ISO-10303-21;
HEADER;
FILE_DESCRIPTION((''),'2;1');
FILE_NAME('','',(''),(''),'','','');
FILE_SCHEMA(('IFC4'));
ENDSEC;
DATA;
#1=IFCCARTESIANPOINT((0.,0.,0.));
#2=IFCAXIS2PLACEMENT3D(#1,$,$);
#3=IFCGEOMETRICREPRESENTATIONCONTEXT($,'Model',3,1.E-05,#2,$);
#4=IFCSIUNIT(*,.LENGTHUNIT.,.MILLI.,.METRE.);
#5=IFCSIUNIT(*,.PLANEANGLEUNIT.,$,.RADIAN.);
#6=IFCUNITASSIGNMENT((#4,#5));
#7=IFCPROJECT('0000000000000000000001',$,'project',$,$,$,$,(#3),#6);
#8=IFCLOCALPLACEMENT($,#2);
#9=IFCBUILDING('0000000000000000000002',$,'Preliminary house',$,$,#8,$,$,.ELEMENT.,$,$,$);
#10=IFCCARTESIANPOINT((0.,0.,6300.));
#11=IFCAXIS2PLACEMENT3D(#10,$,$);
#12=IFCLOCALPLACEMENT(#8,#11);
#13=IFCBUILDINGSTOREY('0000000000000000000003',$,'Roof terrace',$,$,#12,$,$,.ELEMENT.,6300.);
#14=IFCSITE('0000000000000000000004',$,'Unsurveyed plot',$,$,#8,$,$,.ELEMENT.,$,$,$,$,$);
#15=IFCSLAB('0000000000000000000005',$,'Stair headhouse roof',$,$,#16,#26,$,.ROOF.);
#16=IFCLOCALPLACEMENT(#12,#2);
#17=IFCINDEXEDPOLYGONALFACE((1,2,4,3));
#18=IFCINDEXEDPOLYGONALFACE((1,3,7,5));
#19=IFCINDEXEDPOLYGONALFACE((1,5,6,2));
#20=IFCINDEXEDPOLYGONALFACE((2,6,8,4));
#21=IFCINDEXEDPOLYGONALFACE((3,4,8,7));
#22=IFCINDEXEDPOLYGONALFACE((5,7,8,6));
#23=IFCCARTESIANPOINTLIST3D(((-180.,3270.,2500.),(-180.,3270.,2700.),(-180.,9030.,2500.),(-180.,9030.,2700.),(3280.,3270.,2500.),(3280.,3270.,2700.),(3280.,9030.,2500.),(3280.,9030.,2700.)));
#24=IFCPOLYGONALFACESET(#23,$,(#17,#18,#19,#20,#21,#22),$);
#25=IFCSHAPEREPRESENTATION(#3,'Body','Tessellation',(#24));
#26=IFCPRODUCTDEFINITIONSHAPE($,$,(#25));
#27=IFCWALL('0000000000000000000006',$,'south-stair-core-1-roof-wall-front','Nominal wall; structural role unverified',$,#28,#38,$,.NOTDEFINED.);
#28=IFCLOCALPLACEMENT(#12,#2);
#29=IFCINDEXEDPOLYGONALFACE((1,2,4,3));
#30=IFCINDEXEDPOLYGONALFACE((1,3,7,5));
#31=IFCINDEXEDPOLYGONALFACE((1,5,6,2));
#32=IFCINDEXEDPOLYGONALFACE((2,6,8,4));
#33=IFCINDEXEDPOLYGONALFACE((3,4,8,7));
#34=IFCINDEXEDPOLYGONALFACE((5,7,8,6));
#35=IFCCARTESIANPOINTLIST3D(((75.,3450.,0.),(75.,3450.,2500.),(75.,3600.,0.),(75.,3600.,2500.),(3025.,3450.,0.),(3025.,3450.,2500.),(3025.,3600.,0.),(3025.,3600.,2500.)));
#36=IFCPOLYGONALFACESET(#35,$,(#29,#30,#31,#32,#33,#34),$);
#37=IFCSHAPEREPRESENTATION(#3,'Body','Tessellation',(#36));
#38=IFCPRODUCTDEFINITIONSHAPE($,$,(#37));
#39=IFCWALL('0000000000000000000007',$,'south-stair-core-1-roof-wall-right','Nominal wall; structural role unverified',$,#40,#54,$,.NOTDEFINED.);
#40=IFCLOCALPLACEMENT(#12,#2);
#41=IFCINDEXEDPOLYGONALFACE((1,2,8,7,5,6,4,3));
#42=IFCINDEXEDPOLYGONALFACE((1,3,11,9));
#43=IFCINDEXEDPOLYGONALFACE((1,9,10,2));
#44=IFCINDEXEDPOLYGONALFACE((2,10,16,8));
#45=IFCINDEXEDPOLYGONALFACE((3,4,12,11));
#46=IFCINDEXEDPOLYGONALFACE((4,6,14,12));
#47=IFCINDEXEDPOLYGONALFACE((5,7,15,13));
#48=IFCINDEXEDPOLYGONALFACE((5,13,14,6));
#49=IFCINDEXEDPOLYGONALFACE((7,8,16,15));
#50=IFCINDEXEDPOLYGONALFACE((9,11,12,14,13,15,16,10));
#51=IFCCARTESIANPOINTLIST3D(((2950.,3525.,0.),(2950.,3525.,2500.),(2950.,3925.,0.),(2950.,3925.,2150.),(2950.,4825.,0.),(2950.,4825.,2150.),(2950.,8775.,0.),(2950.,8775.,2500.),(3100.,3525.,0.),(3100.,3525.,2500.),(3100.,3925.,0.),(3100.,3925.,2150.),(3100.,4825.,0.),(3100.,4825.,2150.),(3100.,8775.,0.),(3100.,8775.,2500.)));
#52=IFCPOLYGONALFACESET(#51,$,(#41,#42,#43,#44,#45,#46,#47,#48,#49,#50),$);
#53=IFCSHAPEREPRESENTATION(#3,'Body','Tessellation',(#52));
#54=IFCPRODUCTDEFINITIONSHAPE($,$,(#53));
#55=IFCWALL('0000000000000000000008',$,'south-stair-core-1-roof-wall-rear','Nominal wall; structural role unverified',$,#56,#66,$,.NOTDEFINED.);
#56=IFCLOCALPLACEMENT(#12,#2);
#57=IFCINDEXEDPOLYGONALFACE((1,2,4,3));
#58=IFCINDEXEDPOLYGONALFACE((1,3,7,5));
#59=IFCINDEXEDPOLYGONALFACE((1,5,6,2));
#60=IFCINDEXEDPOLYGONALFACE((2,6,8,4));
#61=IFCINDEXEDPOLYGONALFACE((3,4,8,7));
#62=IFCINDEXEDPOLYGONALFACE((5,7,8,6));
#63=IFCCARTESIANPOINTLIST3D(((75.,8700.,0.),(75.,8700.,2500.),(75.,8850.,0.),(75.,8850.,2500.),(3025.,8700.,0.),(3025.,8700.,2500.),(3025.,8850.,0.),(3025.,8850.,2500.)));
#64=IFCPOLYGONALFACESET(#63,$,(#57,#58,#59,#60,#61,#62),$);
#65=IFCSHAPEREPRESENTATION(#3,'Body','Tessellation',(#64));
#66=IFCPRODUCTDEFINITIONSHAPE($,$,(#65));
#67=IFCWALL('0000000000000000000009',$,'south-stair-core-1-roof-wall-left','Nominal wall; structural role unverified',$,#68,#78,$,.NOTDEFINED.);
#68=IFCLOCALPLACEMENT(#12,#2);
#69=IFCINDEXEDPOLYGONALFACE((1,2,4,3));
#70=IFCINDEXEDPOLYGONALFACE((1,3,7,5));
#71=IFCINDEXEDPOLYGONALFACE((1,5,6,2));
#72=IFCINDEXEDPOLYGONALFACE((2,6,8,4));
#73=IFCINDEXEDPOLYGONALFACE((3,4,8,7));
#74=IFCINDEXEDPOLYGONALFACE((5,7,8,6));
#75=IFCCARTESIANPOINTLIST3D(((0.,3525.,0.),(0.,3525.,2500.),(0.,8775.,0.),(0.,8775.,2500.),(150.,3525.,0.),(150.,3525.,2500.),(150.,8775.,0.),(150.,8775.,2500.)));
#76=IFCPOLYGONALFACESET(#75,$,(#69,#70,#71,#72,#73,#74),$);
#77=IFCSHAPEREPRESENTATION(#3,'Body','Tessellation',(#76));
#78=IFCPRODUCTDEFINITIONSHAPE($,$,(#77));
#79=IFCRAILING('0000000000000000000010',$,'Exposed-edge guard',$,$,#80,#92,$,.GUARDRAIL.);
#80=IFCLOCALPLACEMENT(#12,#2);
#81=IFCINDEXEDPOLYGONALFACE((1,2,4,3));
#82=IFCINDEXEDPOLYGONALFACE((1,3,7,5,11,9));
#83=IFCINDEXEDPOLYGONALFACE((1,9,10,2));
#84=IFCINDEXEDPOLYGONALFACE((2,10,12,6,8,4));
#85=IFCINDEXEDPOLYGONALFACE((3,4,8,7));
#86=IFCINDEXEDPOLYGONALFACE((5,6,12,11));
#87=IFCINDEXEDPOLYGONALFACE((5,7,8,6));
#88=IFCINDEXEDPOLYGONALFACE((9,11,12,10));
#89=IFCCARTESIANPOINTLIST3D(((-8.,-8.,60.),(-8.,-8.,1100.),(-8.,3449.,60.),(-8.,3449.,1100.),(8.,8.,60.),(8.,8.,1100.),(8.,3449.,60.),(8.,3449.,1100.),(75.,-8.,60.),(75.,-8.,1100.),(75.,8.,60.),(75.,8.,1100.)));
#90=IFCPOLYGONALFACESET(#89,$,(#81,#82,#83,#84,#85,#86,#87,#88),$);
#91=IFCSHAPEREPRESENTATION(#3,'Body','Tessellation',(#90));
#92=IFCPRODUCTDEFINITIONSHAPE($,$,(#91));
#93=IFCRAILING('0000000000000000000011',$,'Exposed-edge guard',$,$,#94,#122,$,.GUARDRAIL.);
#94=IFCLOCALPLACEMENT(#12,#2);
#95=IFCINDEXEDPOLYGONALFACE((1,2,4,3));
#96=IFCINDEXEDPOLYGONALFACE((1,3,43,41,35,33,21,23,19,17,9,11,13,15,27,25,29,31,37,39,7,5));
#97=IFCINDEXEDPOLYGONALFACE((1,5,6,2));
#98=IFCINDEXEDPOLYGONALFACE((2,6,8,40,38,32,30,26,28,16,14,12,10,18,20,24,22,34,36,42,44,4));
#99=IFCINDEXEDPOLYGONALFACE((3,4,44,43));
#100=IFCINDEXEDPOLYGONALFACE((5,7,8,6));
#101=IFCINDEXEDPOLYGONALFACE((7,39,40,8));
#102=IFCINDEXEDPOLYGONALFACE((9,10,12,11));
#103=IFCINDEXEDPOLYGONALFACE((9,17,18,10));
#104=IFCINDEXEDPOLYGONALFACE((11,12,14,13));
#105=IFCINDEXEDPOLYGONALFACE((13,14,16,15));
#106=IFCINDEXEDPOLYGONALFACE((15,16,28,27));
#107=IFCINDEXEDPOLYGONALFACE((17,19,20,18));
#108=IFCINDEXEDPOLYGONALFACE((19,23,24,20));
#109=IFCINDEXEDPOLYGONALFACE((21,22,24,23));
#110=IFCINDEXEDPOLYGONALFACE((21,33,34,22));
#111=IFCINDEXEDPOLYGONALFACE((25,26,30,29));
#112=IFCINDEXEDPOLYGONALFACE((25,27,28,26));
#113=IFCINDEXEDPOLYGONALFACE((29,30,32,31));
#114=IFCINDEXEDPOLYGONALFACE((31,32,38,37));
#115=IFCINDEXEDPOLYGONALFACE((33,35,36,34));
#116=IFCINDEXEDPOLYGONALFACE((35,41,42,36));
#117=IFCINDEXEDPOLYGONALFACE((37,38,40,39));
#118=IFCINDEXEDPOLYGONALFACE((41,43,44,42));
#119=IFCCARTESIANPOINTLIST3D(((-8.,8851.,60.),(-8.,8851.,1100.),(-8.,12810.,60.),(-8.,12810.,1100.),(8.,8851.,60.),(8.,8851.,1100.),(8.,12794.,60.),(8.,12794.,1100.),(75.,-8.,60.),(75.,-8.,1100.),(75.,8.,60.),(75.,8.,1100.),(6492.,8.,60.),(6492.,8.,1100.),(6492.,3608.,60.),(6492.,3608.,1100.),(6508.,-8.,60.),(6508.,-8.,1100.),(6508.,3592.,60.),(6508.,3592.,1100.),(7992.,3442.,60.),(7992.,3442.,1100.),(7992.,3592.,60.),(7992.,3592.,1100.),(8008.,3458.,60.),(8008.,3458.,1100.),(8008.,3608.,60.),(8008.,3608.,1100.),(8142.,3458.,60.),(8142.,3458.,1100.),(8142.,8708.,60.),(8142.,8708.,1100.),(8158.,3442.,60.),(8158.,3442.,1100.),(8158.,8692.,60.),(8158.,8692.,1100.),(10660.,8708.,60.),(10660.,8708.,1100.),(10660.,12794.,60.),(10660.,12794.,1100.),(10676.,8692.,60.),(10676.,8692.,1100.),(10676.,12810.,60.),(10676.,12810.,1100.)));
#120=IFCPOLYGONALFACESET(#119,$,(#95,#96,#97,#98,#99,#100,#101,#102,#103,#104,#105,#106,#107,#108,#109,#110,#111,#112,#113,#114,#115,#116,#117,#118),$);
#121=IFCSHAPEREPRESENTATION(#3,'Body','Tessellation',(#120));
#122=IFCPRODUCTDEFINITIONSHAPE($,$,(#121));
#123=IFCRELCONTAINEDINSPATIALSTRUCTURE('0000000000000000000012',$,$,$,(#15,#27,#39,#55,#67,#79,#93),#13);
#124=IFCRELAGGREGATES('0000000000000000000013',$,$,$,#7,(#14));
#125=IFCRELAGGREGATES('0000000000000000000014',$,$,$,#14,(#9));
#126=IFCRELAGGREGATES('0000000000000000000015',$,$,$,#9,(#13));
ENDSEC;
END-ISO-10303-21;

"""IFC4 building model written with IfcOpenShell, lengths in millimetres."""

from ifc_helpers import new_model, si_unit, frame, origin, place, context, project, spatial, polyline, outline, extrude, element, save


model = new_model("IFC4")

# Units and contexts
model_context = context("Model", 3, precision=1e-05, world=origin())
ifc_project = project(units=[si_unit("LENGTHUNIT", "METRE", prefix="MILLI"), si_unit("PLANEANGLEUNIT", "RADIAN")], contexts=[model_context])

# Site, building, storey
placement_1 = place(None, origin())
site = spatial("IfcSite", under=ifc_project, at=placement_1, Name="Unsurveyed plot", CompositionType="ELEMENT")
building = spatial("IfcBuilding", under=site, at=placement_1, Name="Preliminary house", CompositionType="ELEMENT")
placement_2 = place(placement_1, frame((0.0, 0.0, 6300.0)))
storey = spatial("IfcBuildingStorey", under=building, at=placement_2, Name="Roof terrace", CompositionType="ELEMENT", Elevation=6300.0)

# Slab
element("IfcSlab", 1, at=placement_2, inside=storey, Name="Stair headhouse roof", PredefinedType="ROOF", context=model_context, shape_type="SweptSolid", body=[
    extrude(outline(polyline([(3280.0, 3270.0), (-180.0, 3270.0), (-180.0, 9030.0), (3280.0, 9030.0), (3280.0, 3270.0)])), frame((0.0, 0.0, 2500.0)), (0.0, 0.0, 1.0), 200.0),
])

# Wall
element("IfcWall", 2, at=placement_2, inside=storey, Name="south-stair-core-1-roof-wall-front", Description="Nominal wall; structural role unverified", PredefinedType="NOTDEFINED", context=model_context, shape_type="SweptSolid", body=[
    extrude(outline(polyline([(3025.0, 3600.0), (3025.0, 3450.0), (75.0, 3450.0), (75.0, 3600.0), (3025.0, 3600.0)])), origin(), (0.0, 0.0, 1.0), 2500.0),
])

# Wall, opening
wall_1 = element("IfcWall", 3, at=placement_2, inside=storey, Name="south-stair-core-1-roof-wall-right", Description="Nominal wall; structural role unverified", PredefinedType="NOTDEFINED", context=model_context, shape_type="SweptSolid", body=[
    extrude(outline(polyline([(2950.0, 8775.0), (3100.0, 8775.0), (3100.0, 3525.0), (2950.0, 3525.0), (2950.0, 8775.0)])), origin(), (0.0, 0.0, 1.0), 2500.0),
])
element("IfcOpeningElement", 4, at=placement_2, cuts=wall_1, PredefinedType="OPENING", context=model_context, shape_type="SweptSolid", body=[
    extrude(outline(polyline([(3475.0, 3925.0), (3475.0, 4825.0), (2575.0, 4825.0), (2575.0, 3925.0), (3475.0, 3925.0)])), origin(), (0.0, 0.0, 1.0), 2150.0),
])

# Walls
element("IfcWall", 5, at=placement_2, inside=storey, Name="south-stair-core-1-roof-wall-rear", Description="Nominal wall; structural role unverified", PredefinedType="NOTDEFINED", context=model_context, shape_type="SweptSolid", body=[
    extrude(outline(polyline([(3025.0, 8850.0), (3025.0, 8700.0), (75.0, 8700.0), (75.0, 8850.0), (3025.0, 8850.0)])), origin(), (0.0, 0.0, 1.0), 2500.0),
])
element("IfcWall", 6, at=placement_2, inside=storey, Name="south-stair-core-1-roof-wall-left", Description="Nominal wall; structural role unverified", PredefinedType="NOTDEFINED", context=model_context, shape_type="SweptSolid", body=[
    extrude(outline(polyline([(0.0, 8775.0), (150.0, 8775.0), (150.0, 3525.0), (0.0, 3525.0), (0.0, 8775.0)])), origin(), (0.0, 0.0, 1.0), 2500.0),
])

# Railings
element("IfcRailing", 7, at=placement_2, inside=storey, Name="Exposed-edge guard", PredefinedType="GUARDRAIL", context=model_context, shape_type="SweptSolid", body=[
    extrude(outline(polyline([(-8.0, -8.0), (-8.0, 3449.0), (8.0, 3449.0), (8.0, 8.0), (75.0, 8.0), (75.0, -8.0), (-8.0, -8.0)])), frame((0.0, 0.0, 60.0)), (0.0, 0.0, 1.0), 1040.0),
])
element("IfcRailing", 8, at=placement_2, inside=storey, Name="Exposed-edge guard", PredefinedType="GUARDRAIL", context=model_context, shape_type="SweptSolid", body=[
    extrude(outline(polyline([(-8.0, 12810.0), (10676.0, 12810.0), (10676.0, 8692.0), (8158.0, 8692.0), (8158.0, 3442.0), (7992.0, 3442.0), (7992.0, 3592.0), (6508.0, 3592.0), (6508.0, -8.0), (75.0, -8.0), (75.0, 8.0), (6492.0, 8.0), (6492.0, 3608.0), (8008.0, 3608.0), (8008.0, 3458.0), (8142.0, 3458.0), (8142.0, 8708.0), (10660.0, 8708.0), (10660.0, 12794.0), (8.0, 12794.0), (8.0, 8851.0), (-8.0, 8851.0), (-8.0, 12810.0)])), frame((0.0, 0.0, 60.0)), (0.0, 0.0, 1.0), 1040.0),
])

save(model, "model.ifc")
